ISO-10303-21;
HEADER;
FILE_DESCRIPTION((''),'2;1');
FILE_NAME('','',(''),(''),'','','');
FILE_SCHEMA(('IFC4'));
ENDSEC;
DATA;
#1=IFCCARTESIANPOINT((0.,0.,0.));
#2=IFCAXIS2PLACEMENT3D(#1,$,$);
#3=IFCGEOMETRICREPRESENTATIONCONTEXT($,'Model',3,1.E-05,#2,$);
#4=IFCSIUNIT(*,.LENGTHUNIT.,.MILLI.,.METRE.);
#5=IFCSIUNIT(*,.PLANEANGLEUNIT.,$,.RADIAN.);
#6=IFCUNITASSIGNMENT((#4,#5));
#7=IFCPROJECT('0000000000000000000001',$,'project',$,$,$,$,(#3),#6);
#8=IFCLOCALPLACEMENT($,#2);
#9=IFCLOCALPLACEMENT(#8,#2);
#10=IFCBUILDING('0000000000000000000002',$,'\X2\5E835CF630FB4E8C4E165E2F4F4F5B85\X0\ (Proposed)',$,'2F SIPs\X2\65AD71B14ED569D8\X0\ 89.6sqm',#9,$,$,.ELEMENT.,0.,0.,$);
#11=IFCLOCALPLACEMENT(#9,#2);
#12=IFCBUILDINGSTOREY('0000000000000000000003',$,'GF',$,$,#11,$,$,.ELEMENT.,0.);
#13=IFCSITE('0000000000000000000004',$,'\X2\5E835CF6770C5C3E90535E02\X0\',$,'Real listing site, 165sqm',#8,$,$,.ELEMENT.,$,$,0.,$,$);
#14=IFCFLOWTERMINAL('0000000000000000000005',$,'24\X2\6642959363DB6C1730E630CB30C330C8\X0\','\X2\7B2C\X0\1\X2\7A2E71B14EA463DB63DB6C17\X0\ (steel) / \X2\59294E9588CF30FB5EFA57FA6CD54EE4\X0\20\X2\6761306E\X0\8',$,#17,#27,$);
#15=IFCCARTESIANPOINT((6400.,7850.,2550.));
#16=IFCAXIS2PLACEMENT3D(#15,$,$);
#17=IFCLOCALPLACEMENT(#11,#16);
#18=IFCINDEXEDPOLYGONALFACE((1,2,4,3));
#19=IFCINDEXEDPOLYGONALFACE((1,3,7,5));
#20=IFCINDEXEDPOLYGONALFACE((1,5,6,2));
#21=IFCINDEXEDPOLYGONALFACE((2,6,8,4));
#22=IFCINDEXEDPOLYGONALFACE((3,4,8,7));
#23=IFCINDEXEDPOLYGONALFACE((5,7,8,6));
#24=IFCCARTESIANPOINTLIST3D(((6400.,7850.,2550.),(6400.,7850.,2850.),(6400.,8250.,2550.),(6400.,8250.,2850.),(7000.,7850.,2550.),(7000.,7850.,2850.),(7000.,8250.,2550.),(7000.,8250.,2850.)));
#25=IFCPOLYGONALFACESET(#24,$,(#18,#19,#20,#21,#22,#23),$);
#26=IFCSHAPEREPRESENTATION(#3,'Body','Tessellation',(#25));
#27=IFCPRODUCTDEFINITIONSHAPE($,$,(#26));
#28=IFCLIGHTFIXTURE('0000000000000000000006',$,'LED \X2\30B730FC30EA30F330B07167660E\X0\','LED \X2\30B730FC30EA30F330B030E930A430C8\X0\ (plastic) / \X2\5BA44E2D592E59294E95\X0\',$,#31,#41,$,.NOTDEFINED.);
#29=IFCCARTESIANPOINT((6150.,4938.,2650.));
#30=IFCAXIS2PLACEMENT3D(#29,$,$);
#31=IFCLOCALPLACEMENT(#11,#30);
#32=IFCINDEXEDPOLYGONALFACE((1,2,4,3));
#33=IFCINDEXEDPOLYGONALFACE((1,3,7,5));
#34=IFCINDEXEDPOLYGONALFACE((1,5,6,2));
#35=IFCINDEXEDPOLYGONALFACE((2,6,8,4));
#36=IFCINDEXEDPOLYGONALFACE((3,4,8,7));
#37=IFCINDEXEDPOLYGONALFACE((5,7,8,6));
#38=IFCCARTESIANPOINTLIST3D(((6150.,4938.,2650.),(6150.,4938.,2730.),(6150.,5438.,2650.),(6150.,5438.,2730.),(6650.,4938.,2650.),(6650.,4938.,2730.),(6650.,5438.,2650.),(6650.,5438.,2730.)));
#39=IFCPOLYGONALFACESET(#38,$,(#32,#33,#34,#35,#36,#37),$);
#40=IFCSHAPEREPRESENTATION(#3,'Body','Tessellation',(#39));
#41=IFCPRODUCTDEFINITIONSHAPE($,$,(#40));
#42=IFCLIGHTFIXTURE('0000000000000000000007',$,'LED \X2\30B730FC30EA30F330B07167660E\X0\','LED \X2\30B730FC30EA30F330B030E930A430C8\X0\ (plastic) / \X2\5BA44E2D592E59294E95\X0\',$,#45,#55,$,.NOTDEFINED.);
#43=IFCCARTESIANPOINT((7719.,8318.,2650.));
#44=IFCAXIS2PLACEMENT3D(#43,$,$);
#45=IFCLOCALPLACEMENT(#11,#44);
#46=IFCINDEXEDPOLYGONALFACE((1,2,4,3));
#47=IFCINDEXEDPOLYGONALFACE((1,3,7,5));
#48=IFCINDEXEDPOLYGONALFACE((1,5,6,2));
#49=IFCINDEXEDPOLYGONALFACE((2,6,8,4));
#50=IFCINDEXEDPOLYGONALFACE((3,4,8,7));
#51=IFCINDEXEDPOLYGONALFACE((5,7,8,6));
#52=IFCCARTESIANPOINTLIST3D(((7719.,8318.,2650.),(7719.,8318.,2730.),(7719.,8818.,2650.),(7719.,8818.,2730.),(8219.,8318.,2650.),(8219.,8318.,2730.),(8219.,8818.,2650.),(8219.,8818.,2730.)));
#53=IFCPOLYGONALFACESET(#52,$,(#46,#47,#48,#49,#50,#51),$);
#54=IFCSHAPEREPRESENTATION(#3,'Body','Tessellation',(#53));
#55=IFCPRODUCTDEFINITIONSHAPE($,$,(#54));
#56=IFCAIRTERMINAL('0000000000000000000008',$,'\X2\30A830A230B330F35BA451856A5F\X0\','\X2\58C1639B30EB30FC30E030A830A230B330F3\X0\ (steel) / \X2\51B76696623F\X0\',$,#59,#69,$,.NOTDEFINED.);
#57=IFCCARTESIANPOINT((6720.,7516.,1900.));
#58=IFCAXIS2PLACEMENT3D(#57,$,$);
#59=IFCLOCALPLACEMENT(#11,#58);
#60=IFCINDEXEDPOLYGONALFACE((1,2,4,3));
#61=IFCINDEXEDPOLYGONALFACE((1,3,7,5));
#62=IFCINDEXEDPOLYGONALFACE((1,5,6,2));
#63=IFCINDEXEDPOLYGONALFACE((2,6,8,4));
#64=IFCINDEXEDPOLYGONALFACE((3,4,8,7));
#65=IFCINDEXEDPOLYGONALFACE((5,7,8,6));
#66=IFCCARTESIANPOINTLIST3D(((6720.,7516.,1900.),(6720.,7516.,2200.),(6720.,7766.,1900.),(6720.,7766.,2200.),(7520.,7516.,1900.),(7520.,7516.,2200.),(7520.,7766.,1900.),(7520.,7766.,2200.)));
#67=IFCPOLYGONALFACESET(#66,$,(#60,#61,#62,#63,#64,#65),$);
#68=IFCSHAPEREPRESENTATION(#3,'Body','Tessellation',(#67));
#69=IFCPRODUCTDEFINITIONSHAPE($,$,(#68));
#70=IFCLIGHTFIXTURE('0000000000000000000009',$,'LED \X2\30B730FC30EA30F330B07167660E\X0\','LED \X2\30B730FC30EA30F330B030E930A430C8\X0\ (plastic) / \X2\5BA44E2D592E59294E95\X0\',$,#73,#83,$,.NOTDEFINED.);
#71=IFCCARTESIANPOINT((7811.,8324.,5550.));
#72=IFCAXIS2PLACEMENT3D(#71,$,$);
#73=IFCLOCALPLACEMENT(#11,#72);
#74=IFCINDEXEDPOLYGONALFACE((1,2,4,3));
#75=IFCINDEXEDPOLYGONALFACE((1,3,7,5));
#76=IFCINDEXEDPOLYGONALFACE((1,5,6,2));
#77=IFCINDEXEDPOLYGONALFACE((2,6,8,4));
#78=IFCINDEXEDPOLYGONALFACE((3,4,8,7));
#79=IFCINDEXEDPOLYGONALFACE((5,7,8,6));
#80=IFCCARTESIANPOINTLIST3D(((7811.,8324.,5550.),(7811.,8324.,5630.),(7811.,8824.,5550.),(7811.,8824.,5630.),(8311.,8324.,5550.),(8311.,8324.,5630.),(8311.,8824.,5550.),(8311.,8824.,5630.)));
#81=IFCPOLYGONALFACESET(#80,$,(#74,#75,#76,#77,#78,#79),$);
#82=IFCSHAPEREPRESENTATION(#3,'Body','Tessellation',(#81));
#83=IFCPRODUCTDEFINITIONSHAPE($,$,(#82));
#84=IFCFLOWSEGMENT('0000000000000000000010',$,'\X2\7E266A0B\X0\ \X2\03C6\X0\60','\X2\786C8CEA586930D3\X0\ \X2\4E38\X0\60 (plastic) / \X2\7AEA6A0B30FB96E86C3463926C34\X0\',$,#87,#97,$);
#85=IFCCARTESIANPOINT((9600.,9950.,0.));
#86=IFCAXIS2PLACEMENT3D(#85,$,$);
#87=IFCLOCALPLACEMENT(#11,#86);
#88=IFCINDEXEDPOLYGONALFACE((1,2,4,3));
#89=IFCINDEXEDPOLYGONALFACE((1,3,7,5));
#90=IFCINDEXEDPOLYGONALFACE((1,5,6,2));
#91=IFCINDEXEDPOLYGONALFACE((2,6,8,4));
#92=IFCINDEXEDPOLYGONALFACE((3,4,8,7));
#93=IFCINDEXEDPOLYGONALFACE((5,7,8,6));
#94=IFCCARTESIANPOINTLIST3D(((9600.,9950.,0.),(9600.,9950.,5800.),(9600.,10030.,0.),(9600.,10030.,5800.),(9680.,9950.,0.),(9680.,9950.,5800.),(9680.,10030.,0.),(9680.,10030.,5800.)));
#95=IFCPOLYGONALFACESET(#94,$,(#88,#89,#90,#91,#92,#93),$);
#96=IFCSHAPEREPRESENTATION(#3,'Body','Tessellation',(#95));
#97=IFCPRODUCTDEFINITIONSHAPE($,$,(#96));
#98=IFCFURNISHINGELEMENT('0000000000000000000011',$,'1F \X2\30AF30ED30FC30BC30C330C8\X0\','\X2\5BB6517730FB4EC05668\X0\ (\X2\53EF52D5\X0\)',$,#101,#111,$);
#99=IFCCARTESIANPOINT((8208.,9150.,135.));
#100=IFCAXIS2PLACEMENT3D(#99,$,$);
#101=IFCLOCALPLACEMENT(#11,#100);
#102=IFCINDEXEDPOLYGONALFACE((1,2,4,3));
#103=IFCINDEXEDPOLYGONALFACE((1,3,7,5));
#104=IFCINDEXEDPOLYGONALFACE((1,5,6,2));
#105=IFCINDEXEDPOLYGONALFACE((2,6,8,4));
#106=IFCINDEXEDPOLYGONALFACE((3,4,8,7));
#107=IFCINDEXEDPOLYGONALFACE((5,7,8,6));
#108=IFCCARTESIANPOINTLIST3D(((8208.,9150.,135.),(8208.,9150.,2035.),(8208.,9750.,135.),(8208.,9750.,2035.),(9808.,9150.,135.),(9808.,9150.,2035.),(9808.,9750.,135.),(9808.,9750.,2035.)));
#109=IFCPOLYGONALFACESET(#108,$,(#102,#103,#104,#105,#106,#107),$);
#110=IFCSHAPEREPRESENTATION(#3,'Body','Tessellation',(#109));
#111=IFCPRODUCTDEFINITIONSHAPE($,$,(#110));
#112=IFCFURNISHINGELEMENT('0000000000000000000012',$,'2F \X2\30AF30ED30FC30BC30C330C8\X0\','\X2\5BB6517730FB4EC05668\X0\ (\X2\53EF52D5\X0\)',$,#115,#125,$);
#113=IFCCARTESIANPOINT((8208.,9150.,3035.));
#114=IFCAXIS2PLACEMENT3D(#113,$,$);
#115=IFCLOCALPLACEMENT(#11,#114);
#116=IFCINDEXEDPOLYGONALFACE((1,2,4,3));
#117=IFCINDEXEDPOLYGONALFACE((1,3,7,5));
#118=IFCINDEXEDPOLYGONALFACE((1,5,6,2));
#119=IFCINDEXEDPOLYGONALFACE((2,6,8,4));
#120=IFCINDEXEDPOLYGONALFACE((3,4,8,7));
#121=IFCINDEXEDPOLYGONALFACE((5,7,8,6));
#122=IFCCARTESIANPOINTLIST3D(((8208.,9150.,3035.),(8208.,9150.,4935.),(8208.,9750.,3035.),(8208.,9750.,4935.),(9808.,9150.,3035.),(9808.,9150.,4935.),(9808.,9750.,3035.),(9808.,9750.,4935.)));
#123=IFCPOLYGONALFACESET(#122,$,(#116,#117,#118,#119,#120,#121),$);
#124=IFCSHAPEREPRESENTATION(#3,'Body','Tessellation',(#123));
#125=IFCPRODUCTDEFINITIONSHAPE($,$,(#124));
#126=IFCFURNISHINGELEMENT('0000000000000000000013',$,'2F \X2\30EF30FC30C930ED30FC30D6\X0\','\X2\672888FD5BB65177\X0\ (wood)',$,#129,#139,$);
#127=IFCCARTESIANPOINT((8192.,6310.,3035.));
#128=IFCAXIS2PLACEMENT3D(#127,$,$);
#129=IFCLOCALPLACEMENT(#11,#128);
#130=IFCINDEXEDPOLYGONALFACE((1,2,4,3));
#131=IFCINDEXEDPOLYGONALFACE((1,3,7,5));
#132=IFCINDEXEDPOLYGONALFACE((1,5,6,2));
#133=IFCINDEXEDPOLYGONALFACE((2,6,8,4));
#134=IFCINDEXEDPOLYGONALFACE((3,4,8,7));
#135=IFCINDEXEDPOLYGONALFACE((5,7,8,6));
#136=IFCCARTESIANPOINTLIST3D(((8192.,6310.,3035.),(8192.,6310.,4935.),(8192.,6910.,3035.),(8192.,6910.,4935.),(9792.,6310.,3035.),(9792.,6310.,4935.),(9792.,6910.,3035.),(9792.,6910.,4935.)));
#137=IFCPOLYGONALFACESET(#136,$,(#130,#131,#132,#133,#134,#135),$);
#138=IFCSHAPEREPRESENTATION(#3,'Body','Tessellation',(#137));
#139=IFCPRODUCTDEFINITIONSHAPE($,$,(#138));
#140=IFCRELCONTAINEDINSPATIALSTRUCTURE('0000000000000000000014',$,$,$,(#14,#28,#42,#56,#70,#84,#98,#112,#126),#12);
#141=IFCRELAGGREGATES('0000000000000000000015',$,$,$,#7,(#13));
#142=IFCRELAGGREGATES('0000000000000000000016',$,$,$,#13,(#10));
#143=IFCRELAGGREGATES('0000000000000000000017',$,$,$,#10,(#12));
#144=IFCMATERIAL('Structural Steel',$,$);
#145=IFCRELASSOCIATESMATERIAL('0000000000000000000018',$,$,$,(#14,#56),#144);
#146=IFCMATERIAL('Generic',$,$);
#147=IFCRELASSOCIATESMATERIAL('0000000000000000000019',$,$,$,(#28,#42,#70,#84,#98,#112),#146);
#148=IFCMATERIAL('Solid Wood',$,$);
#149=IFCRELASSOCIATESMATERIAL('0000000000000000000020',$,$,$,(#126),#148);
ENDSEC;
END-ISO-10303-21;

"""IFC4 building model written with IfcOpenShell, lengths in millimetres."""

from ifc_helpers import new_model, si_unit, frame, frame_2d, origin, place, context, project, spatial, rectangle, extrude, material, element, save


model = new_model("IFC4")

# Units and contexts
model_context = context("Model", 3, precision=1e-05, world=origin())
ifc_project = project(units=[si_unit("LENGTHUNIT", "METRE", prefix="MILLI"), si_unit("PLANEANGLEUNIT", "RADIAN")], contexts=[model_context])

# Site, building, storey
site_placement = place(None, origin())
site = spatial("IfcSite", under=ifc_project, at=site_placement, Name="広島県尾道市", ObjectType="Real listing site, 165sqm", CompositionType="ELEMENT", RefElevation=0.0)
building_placement = place(site_placement, origin())
building = spatial("IfcBuilding", under=site, at=building_placement, Name="広島・二世帯住宅 (Proposed)", ObjectType="2F SIPs断熱仕様 89.6sqm", CompositionType="ELEMENT", ElevationOfRefHeight=0.0, ElevationOfTerrain=0.0)
storey_placement = place(building_placement, origin())
storey = spatial("IfcBuildingStorey", under=building, at=storey_placement, Name="GF", CompositionType="ELEMENT", Elevation=0.0)

# Shared definitions
ifc_material_1 = material(Name="Solid Wood")

# Shared definitions
ifc_material_2 = material(Name="Structural Steel")

# Shared definitions
ifc_material_3 = material(Name="Generic")

# Flow terminal
flow_terminal_placement = place(storey_placement, frame((6400.0, 7850.0, 2550.0)))
element("IfcFlowTerminal", 1, at=flow_terminal_placement, inside=storey, material=ifc_material_2, Name="24時間換気ユニット", Description="第1種熱交換換気 (steel) / 天井裏・建基法令20条の8", context=model_context, shape_type="SweptSolid", body=[
    extrude(rectangle(XDim=600.0, YDim=400.0, at=frame_2d((300.0, 200.0))), frame((6400.0, 7850.0, 2550.0)), (0.0, 0.0, 1.0), 300.0),
])

# Light fixtures
light_fixture_1_placement = place(storey_placement, frame((6150.0, 4938.0, 2650.0)))
element("IfcLightFixture", 2, at=light_fixture_1_placement, inside=storey, material=ifc_material_3, Name="LED シーリング照明", Description="LED シーリングライト (plastic) / 室中央天井", PredefinedType="NOTDEFINED", context=model_context, shape_type="SweptSolid", body=[
    extrude(rectangle(XDim=500.0, YDim=500.0, at=frame_2d((250.0, 250.0))), frame((6150.0, 4938.0, 2650.0)), (0.0, 0.0, 1.0), 80.0),
])
light_fixture_2_placement = place(storey_placement, frame((7719.0, 8318.0, 2650.0)))
element("IfcLightFixture", 3, at=light_fixture_2_placement, inside=storey, material=ifc_material_3, Name="LED シーリング照明", Description="LED シーリングライト (plastic) / 室中央天井", PredefinedType="NOTDEFINED", context=model_context, shape_type="SweptSolid", body=[
    extrude(rectangle(XDim=500.0, YDim=500.0, at=frame_2d((250.0, 250.0))), frame((7719.0, 8318.0, 2650.0)), (0.0, 0.0, 1.0), 80.0),
])

# Air terminal
air_terminal_placement = place(storey_placement, frame((6720.0, 7516.0, 1900.0)))
element("IfcAirTerminal", 4, at=air_terminal_placement, inside=storey, material=ifc_material_2, Name="エアコン室内機", Description="壁掛ルームエアコン (steel) / 冷暖房", PredefinedType="NOTDEFINED", context=model_context, shape_type="SweptSolid", body=[
    extrude(rectangle(XDim=800.0, YDim=250.0, at=frame_2d((400.0, 125.0))), frame((6720.0, 7516.0, 1900.0)), (0.0, 0.0, 1.0), 300.0),
])

# Light fixture
light_fixture_3_placement = place(storey_placement, frame((7811.0, 8324.0, 5550.0)))
element("IfcLightFixture", 5, at=light_fixture_3_placement, inside=storey, material=ifc_material_3, Name="LED シーリング照明", Description="LED シーリングライト (plastic) / 室中央天井", PredefinedType="NOTDEFINED", context=model_context, shape_type="SweptSolid", body=[
    extrude(rectangle(XDim=500.0, YDim=500.0, at=frame_2d((250.0, 250.0))), frame((7811.0, 8324.0, 5550.0)), (0.0, 0.0, 1.0), 80.0),
])

# Flow segment
flow_segment_placement = place(storey_placement, frame((9600.0, 9950.0, 0.0)))
element("IfcFlowSegment", 6, at=flow_segment_placement, inside=storey, material=ifc_material_3, Name="縦樋 φ60", Description="硬質塩ビ 丸60 (plastic) / 竪樋・雨水排水", context=model_context, shape_type="SweptSolid", body=[
    extrude(rectangle(XDim=80.0, YDim=80.0, at=frame_2d((40.0, 40.0))), frame((9600.0, 9950.0, 0.0)), (0.0, 0.0, 1.0), 5800.0),
])

# Furnishing elements
furnishing_1_placement = place(storey_placement, frame((8208.0, 9150.0, 135.0)))
element("IfcFurnishingElement", 7, at=furnishing_1_placement, inside=storey, material=ifc_material_3, Name="1F クローゼット", Description="家具・什器 (可動)", context=model_context, shape_type="SweptSolid", body=[
    extrude(rectangle(XDim=1600.0, YDim=600.0, at=frame_2d((800.0, 300.0))), frame((8208.0, 9150.0, 135.0)), (0.0, 0.0, 1.0), 1900.0),
])
furnishing_2_placement = place(storey_placement, frame((8208.0, 9150.0, 3035.0)))
element("IfcFurnishingElement", 8, at=furnishing_2_placement, inside=storey, material=ifc_material_3, Name="2F クローゼット", Description="家具・什器 (可動)", context=model_context, shape_type="SweptSolid", body=[
    extrude(rectangle(XDim=1600.0, YDim=600.0, at=frame_2d((800.0, 300.0))), frame((8208.0, 9150.0, 3035.0)), (0.0, 0.0, 1.0), 1900.0),
])
furnishing_3_placement = place(storey_placement, frame((8192.0, 6310.0, 3035.0)))
element("IfcFurnishingElement", 9, at=furnishing_3_placement, inside=storey, material=ifc_material_1, Name="2F ワードローブ", Description="木製家具 (wood)", context=model_context, shape_type="SweptSolid", body=[
    extrude(rectangle(XDim=1600.0, YDim=600.0, at=frame_2d((800.0, 300.0))), frame((8192.0, 6310.0, 3035.0)), (0.0, 0.0, 1.0), 1900.0),
])

save(model, "model.ifc")
